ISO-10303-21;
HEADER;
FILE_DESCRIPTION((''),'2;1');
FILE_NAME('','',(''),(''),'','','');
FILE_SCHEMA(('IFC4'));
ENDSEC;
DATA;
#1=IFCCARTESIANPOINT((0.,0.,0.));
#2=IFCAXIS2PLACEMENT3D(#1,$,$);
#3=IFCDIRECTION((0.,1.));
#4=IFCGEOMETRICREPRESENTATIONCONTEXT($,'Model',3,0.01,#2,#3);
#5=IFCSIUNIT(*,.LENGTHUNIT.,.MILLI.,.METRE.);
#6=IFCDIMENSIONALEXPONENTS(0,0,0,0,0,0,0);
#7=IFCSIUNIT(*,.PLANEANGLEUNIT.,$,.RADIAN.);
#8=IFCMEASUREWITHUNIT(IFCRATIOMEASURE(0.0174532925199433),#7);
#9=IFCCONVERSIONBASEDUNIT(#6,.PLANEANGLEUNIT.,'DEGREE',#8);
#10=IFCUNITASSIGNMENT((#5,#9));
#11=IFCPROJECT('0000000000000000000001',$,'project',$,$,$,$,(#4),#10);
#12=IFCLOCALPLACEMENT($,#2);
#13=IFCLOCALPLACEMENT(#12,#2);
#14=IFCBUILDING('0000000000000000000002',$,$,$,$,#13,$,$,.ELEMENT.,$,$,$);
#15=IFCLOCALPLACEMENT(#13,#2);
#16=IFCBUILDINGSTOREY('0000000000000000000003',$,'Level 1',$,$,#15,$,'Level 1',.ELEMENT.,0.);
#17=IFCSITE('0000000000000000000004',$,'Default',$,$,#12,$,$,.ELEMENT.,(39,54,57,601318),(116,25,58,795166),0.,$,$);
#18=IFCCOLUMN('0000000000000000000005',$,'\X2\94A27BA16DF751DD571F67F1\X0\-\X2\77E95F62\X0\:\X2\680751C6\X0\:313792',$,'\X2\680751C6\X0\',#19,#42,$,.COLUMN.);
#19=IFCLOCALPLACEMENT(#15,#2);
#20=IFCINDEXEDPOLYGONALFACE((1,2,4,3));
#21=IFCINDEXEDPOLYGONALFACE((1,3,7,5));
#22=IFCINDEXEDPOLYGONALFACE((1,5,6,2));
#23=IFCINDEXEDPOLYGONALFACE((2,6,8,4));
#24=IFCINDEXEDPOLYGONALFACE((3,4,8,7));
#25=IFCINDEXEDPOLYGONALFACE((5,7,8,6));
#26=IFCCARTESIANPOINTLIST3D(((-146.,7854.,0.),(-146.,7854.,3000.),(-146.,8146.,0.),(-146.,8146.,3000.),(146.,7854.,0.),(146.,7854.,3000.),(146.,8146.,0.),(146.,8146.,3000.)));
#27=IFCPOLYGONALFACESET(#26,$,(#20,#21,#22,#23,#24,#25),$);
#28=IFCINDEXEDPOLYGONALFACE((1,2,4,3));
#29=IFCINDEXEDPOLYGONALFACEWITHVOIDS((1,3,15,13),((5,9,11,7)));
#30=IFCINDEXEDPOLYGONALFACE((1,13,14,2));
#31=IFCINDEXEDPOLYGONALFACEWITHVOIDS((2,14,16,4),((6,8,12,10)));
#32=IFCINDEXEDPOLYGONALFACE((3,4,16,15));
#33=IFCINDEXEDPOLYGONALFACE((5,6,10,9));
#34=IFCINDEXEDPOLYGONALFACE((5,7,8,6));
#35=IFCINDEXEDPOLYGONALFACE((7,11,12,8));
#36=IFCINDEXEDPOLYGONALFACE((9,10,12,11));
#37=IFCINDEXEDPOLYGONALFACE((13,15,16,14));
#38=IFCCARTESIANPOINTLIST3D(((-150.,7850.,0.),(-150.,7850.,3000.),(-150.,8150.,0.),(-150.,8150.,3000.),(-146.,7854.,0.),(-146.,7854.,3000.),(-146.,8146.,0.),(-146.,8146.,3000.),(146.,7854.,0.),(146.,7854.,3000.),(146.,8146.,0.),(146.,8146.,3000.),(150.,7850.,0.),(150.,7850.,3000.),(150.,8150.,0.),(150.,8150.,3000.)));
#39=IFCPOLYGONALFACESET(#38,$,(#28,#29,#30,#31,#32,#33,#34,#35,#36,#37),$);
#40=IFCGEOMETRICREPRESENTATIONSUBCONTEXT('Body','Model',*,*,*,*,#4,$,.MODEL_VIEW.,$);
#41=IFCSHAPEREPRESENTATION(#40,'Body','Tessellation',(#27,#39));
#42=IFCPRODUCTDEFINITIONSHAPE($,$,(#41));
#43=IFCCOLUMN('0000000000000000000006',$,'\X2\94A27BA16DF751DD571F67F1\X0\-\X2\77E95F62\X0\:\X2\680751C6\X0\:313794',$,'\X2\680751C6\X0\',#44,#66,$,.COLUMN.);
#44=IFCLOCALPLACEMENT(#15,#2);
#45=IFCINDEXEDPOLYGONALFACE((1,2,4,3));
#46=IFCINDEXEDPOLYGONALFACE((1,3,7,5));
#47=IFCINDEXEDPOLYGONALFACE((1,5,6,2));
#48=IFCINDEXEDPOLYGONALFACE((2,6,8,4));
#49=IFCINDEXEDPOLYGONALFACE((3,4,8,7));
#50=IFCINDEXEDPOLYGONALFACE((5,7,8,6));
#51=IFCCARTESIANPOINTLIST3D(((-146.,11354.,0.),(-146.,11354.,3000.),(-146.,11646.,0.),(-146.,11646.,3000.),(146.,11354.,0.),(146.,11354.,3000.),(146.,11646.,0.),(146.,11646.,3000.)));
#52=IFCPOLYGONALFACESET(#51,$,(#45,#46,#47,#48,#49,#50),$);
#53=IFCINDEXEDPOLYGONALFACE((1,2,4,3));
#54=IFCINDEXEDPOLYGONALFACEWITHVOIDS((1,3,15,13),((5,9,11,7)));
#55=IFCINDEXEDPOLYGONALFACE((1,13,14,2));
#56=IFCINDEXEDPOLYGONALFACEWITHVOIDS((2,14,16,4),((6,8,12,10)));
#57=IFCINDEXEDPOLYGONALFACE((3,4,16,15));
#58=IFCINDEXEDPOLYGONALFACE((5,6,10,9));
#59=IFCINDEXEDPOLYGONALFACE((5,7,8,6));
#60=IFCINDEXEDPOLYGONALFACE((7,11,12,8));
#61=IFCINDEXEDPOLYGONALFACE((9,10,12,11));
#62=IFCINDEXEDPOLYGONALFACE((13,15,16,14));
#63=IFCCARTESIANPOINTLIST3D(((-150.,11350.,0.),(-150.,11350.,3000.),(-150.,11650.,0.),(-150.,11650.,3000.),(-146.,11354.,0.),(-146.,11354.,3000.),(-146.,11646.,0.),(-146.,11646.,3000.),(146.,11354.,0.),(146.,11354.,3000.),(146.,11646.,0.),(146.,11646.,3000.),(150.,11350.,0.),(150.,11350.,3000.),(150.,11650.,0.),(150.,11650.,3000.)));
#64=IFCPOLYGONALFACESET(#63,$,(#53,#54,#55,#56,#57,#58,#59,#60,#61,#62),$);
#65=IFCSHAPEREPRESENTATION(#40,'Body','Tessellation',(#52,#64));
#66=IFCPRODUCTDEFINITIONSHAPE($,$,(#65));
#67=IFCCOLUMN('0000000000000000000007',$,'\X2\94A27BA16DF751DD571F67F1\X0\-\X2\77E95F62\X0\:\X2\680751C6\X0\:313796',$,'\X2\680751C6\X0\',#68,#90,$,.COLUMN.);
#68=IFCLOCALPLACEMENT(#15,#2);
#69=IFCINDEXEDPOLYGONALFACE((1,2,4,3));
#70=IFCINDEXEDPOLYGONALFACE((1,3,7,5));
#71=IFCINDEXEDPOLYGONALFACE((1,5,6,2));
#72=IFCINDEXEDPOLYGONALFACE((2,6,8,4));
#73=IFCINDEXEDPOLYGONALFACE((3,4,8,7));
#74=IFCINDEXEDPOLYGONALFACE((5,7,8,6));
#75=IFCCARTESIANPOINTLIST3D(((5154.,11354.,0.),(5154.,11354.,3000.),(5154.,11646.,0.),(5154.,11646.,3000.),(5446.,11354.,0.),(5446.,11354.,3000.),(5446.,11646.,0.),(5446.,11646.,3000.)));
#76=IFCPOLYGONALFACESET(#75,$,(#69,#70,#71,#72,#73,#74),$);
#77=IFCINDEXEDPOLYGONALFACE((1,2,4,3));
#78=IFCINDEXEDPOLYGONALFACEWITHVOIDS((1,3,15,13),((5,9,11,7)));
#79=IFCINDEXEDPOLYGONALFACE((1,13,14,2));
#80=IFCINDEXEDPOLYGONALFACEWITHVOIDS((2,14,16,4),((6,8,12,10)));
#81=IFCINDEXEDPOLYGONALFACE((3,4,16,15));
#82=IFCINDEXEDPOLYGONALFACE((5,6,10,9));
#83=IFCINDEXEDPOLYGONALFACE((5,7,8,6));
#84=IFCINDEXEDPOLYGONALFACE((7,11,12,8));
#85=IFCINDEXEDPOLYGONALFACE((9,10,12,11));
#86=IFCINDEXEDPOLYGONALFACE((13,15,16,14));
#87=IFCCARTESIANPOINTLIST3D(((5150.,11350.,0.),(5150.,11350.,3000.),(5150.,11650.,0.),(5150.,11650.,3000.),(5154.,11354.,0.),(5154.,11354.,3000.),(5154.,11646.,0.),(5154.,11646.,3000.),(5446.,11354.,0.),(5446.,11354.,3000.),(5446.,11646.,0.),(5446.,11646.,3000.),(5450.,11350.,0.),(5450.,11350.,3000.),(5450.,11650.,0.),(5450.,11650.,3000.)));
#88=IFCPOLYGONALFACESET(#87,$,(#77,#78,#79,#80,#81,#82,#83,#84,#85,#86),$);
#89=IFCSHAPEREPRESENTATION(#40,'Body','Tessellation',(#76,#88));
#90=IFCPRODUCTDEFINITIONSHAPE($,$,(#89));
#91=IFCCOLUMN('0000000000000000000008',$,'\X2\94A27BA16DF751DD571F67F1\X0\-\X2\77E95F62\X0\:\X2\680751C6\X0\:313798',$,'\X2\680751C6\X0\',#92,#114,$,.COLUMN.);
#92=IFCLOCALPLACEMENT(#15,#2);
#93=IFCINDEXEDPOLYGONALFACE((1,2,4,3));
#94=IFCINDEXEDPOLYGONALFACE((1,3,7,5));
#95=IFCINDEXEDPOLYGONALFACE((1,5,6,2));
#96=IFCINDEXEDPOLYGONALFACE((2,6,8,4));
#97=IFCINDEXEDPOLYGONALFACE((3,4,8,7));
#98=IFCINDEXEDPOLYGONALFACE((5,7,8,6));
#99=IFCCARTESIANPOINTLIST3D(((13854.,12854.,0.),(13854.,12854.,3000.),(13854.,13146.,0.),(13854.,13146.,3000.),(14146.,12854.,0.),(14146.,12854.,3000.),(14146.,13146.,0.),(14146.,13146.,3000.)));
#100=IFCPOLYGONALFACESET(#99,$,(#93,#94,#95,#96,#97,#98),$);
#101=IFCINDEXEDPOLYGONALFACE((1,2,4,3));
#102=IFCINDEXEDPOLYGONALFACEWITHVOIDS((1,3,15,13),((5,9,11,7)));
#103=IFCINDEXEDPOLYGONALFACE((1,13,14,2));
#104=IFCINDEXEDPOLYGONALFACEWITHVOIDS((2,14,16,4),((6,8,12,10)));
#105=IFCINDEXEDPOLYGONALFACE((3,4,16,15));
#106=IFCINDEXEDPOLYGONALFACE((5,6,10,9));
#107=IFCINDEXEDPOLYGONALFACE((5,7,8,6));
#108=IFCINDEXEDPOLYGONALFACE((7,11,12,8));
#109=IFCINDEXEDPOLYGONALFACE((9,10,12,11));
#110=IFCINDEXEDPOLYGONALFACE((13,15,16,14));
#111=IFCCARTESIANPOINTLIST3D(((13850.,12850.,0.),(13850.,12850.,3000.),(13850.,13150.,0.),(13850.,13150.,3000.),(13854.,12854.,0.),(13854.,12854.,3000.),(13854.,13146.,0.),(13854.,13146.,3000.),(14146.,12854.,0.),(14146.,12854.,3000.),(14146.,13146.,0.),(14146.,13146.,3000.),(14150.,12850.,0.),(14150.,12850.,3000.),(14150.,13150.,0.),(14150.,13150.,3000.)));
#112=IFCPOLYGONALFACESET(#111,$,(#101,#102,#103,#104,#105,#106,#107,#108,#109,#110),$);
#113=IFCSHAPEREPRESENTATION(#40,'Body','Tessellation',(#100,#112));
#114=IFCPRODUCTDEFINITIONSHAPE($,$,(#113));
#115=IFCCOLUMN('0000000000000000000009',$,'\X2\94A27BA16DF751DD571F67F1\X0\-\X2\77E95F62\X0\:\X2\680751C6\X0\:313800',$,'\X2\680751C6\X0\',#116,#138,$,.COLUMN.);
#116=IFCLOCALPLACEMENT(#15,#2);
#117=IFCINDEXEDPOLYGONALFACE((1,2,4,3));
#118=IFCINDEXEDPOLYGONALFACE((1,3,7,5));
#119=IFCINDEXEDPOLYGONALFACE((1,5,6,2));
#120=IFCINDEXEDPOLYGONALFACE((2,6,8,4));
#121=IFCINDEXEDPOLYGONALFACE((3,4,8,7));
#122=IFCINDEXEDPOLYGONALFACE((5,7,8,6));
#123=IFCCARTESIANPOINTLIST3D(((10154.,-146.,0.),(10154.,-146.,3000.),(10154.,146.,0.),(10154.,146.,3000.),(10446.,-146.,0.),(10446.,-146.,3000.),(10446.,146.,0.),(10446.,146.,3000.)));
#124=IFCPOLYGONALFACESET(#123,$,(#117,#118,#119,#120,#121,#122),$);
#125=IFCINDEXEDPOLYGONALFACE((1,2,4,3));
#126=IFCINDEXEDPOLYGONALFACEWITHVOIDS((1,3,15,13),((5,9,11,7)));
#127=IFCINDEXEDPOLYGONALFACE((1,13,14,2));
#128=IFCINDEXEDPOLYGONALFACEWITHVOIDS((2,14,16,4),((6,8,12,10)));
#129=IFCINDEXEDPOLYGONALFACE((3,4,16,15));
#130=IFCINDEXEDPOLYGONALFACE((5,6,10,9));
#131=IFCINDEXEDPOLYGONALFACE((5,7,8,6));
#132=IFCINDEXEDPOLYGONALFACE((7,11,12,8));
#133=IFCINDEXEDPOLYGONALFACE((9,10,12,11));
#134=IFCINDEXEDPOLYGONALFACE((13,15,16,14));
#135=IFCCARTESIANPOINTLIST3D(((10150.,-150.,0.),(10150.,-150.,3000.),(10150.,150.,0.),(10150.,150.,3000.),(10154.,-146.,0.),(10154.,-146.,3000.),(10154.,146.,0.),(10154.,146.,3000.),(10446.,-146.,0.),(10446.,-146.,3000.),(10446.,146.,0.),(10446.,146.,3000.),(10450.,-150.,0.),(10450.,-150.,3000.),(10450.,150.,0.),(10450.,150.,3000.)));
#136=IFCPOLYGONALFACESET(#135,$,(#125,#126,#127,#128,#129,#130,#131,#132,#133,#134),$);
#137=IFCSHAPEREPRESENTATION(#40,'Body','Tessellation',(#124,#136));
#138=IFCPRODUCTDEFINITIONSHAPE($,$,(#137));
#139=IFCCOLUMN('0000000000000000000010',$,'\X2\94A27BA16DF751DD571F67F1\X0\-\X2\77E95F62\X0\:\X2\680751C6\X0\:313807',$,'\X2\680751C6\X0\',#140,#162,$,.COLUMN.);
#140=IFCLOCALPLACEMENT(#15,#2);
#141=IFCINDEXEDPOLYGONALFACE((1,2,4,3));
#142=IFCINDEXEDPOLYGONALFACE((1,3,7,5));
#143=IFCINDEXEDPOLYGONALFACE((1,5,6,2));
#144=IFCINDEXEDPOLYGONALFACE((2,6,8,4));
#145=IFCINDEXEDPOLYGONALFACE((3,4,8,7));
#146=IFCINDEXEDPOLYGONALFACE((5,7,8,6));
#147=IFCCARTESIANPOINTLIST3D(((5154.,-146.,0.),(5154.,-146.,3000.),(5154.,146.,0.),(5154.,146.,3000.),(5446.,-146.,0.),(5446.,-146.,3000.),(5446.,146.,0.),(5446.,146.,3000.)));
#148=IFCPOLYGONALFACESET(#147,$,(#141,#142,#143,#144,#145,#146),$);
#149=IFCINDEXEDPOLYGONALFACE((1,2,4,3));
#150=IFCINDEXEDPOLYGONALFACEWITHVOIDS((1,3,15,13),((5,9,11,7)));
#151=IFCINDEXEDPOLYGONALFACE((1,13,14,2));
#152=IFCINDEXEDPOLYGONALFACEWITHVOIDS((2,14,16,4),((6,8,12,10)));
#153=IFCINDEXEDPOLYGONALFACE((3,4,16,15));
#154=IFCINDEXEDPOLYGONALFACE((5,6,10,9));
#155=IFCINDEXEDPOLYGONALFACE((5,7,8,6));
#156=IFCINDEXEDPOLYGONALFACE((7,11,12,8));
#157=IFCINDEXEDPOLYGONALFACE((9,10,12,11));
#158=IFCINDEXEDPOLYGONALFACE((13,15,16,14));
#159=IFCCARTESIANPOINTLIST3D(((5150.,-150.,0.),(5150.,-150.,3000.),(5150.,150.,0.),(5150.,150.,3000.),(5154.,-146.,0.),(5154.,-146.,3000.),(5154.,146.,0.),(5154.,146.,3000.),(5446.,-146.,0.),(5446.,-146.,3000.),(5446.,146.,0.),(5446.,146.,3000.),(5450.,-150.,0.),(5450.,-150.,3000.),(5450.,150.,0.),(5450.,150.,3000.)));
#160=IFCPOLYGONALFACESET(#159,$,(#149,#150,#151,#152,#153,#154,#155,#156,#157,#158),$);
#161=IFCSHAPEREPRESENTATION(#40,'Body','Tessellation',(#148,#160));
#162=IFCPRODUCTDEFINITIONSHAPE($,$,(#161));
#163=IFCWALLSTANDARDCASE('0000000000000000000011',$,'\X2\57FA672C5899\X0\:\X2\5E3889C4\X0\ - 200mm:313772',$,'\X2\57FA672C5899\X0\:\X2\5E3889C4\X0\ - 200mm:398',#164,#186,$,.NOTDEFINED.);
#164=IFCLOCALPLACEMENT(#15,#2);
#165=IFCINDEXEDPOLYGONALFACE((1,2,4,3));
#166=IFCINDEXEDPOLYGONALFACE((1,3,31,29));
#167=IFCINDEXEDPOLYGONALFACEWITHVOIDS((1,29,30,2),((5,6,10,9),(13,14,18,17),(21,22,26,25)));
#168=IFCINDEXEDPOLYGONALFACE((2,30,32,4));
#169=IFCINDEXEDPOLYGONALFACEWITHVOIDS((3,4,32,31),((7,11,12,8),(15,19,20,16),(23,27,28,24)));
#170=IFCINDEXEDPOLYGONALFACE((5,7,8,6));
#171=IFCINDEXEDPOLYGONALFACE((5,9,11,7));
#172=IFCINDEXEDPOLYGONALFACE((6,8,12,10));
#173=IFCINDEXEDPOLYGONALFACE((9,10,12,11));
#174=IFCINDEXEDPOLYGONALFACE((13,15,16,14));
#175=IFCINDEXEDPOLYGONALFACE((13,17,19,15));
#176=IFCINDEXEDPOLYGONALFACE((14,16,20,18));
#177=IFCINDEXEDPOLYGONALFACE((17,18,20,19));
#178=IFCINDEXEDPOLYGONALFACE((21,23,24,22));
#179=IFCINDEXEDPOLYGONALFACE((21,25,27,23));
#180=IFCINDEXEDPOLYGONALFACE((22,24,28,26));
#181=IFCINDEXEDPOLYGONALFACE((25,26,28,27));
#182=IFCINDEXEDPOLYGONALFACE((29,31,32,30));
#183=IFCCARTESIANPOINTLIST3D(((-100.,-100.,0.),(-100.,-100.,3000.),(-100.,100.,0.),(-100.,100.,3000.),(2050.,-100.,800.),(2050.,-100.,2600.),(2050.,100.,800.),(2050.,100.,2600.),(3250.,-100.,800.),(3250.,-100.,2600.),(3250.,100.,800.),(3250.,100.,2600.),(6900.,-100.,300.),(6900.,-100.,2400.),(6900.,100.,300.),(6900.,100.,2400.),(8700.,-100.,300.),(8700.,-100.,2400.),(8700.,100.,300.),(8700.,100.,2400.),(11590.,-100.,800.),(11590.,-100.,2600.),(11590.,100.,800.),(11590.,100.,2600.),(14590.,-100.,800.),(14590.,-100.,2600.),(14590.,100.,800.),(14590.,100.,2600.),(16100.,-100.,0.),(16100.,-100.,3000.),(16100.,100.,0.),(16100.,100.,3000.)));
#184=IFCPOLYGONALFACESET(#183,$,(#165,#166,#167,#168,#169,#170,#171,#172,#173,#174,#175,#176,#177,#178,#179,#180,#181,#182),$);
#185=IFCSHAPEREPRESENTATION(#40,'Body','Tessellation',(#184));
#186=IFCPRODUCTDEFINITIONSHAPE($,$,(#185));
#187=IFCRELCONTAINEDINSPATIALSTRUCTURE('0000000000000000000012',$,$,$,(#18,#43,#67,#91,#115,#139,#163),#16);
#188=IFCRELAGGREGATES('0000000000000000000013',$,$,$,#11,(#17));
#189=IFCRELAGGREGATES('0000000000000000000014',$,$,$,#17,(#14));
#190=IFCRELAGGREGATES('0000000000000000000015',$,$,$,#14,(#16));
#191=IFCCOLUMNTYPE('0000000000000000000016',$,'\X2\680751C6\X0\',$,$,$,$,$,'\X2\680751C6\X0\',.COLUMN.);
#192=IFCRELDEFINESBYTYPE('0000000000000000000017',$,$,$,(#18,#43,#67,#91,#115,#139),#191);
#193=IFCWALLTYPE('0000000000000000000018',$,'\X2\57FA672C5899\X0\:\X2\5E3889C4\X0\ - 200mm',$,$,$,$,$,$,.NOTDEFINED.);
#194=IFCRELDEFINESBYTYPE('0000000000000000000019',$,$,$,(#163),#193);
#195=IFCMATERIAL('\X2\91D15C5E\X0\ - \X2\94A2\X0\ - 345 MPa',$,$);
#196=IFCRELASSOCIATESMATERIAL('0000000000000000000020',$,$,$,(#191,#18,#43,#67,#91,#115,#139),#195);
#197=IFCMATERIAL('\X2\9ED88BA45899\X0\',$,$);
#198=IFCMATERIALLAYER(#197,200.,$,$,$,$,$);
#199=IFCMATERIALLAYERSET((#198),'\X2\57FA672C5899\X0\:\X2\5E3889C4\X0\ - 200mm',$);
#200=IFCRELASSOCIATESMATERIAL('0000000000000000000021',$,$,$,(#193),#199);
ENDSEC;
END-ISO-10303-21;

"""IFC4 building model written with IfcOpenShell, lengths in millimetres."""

from ifc_helpers import new_model, entity, si_unit, converted_unit, direction, frame, frame_2d, origin, origin_with_axes, origin_2d_with_axis, place, context, subcontext, project, spatial, polyline, rectangle, outline, extrude, source, transform, mapped, material, layer, layer_set, type_object, type_shapes, element, save


model = new_model("IFC4")

# Units and contexts
model_context_1 = context("Model", 3, precision=0.01, world=origin(), true_north=direction((0.0, 1.0)))
model_context_2 = context("Model", 3, precision=0.0, world=origin_with_axes(), true_north=direction((0.0, 1.0)))
body_context_1 = subcontext(model_context_1, "Body", "Model", "MODEL_VIEW")
body_context_2 = subcontext(model_context_2, "Body", "Model", "MODEL_VIEW")
ifc_project = project(units=[si_unit("LENGTHUNIT", "METRE", prefix="MILLI"), converted_unit("PLANEANGLEUNIT", "DEGREE", entity("IfcRatioMeasure", 0.0174532925199433), si_unit("PLANEANGLEUNIT", "RADIAN"), dimensions=[0, 0, 0, 0, 0, 0, 0])], contexts=[model_context_1])

# Site, building, storey
site_placement = place(None, origin())
site = spatial("IfcSite", under=ifc_project, at=site_placement, Name="Default", CompositionType="ELEMENT", RefLatitude=(39, 54, 57, 601318), RefLongitude=(116, 25, 58, 795166), RefElevation=0.0)
building_placement = place(site_placement, origin())
building = spatial("IfcBuilding", under=site, at=building_placement, CompositionType="ELEMENT")
storey_placement = place(building_placement, origin())
storey = spatial("IfcBuildingStorey", under=building, at=storey_placement, Name="Level 1", LongName="Level 1", CompositionType="ELEMENT", Elevation=0.0)

# Columns
ifc_material_1 = material(Name="金属 - 钢 - 345 MPa")
column_type = type_object("IfcColumnType", Name="标准", ElementType="标准", PredefinedType="COLUMN", material=ifc_material_1)
shared_shape = source(origin(), body_context_1, "Body", "SweptSolid", [
    extrude(rectangle(XDim=292.0, YDim=292.0, at=origin_2d_with_axis()), frame((0.0, 0.0, 0.0), z_axis=(0.0, 0.0, 1.0), x_axis=(-1.0, 0.0, 0.0)), (0.0, 0.0, 1.0), 3000.0),
    extrude(outline(polyline([(-150.0, -150.0), (150.0, -150.0), (150.0, 150.0), (-150.0, 150.0), (-150.0, -150.0)]), holes=[polyline([(-146.0, -146.0), (-146.0, 146.0), (146.0, 146.0), (146.0, -146.0), (-146.0, -146.0)])]), frame((0.0, 0.0, 0.0), z_axis=(0.0, 0.0, 1.0), x_axis=(-1.0, 0.0, 0.0)), (0.0, 0.0, 1.0), 3000.0),
])
type_shapes(column_type, [shared_shape])
for number, where, name in (
    (1, (0.0, 8000.0, 0.0), "钢管混凝土柱-矩形:标准:313792"),
    (2, (0.0, 11500.0, 0.0), "钢管混凝土柱-矩形:标准:313794"),
    (3, (5300.0, 11500.0, 0.0), "钢管混凝土柱-矩形:标准:313796"),
    (4, (14000.0, 13000.0, 0.0), "钢管混凝土柱-矩形:标准:313798"),
    (5, (10300.0, 0.0, 0.0), "钢管混凝土柱-矩形:标准:313800"),
    (6, (5300.0, 0.0, 0.0), "钢管混凝土柱-矩形:标准:313807"),
):
    element("IfcColumn", number, at=place(storey_placement, frame(where)), inside=storey, type_object=column_type, material=ifc_material_1, Name=name, ObjectType="标准", PredefinedType="COLUMN", context=body_context_1, shape_type="MappedRepresentation", body=[
        mapped(shared_shape, transform((0.0, 0.0, 0.0), scale=1.0)),
    ])

# Wall, openings
ifc_material_2 = material(Name="默认墙")
ifc_layer_1 = layer(ifc_material_2, 200.0)
ifc_layer_set_1 = layer_set([ifc_layer_1], Name="基本墙:常规 - 200mm")
wall_type_1 = type_object("IfcWallType", Name="基本墙:常规 - 200mm", PredefinedType="NOTDEFINED", material=ifc_layer_set_1)
wall_1_placement = place(storey_placement, frame((16100.0, 0.0, 0.0), z_axis=(0.0, 0.0, 1.0), x_axis=(-1.0, 0.0, 0.0)))
wall_1 = element("IfcWallStandardCase", 7, at=wall_1_placement, inside=storey, type_object=wall_type_1, Name="基本墙:常规 - 200mm:313772", ObjectType="基本墙:常规 - 200mm:398", PredefinedType="NOTDEFINED", context=body_context_1, shape_type="SweptSolid", body=[
    extrude(rectangle(XDim=16200.0, YDim=200.0, at=frame_2d((8100.0, 0.0), x_axis=(-1.0, 0.0))), origin(), (0.0, 0.0, 1.0), 3000.0),
])
placement_1 = place(None, origin_with_axes())
placement_2 = place(placement_1, origin_with_axes())
placement_3 = place(placement_2, origin_with_axes())
placement_4 = place(placement_3, frame((16000.0, 0.0, 0.0), z_axis=(0.0, 0.0, 1.0), x_axis=(-1.0, 0.0, 0.0)))
opening_1_placement = place(placement_4, frame((13350.0, 0.0, 800.0), z_axis=(0.0, 0.0, 1.0), x_axis=(1.0, 0.0, 0.0)))
element("IfcOpeningElement", 8, at=opening_1_placement, cuts=wall_1, context=body_context_2, shape_type="SweptSolid", body=[
    extrude(outline(polyline([(-600.0, 0.0), (-600.0, -1800.0), (600.0, -1800.0), (600.0, 0.0), (-600.0, 0.0)])), frame((0.0, -100.0, 0.0), z_axis=(0.0, 1.0, 0.0), x_axis=(1.0, 0.0, 0.0)), (0.0, 0.0, 1.0), 200.0),
])
opening_2_placement = place(placement_4, frame((2910.0, 0.0, 800.0), z_axis=(0.0, 0.0, 1.0), x_axis=(1.0, 0.0, 0.0)))
element("IfcOpeningElement", 9, at=opening_2_placement, cuts=wall_1, context=body_context_2, shape_type="SweptSolid", body=[
    extrude(outline(polyline([(-1500.0, 0.0), (-1500.0, -1800.0), (1500.0, -1800.0), (1500.0, 0.0), (-1500.0, 0.0)])), frame((0.0, -100.0, 0.0), z_axis=(0.0, 1.0, 0.0), x_axis=(1.0, 0.0, 0.0)), (0.0, 0.0, 1.0), 200.0),
])
opening_3_placement = place(placement_4, frame((8200.0, 0.0, 300.0), z_axis=(0.0, 0.0, 1.0), x_axis=(1.0, 0.0, 0.0)))
element("IfcOpeningElement", 10, at=opening_3_placement, cuts=wall_1, context=body_context_2, shape_type="SweptSolid", body=[
    extrude(outline(polyline([(-900.0, 0.0), (-900.0, -2100.0), (900.0, -2100.0), (900.0, 0.0), (-900.0, 0.0)])), frame((0.0, -100.0, 0.0), z_axis=(0.0, 1.0, 0.0), x_axis=(1.0, 0.0, 0.0)), (0.0, 0.0, 1.0), 200.0),
])

save(model, "model.ifc")
